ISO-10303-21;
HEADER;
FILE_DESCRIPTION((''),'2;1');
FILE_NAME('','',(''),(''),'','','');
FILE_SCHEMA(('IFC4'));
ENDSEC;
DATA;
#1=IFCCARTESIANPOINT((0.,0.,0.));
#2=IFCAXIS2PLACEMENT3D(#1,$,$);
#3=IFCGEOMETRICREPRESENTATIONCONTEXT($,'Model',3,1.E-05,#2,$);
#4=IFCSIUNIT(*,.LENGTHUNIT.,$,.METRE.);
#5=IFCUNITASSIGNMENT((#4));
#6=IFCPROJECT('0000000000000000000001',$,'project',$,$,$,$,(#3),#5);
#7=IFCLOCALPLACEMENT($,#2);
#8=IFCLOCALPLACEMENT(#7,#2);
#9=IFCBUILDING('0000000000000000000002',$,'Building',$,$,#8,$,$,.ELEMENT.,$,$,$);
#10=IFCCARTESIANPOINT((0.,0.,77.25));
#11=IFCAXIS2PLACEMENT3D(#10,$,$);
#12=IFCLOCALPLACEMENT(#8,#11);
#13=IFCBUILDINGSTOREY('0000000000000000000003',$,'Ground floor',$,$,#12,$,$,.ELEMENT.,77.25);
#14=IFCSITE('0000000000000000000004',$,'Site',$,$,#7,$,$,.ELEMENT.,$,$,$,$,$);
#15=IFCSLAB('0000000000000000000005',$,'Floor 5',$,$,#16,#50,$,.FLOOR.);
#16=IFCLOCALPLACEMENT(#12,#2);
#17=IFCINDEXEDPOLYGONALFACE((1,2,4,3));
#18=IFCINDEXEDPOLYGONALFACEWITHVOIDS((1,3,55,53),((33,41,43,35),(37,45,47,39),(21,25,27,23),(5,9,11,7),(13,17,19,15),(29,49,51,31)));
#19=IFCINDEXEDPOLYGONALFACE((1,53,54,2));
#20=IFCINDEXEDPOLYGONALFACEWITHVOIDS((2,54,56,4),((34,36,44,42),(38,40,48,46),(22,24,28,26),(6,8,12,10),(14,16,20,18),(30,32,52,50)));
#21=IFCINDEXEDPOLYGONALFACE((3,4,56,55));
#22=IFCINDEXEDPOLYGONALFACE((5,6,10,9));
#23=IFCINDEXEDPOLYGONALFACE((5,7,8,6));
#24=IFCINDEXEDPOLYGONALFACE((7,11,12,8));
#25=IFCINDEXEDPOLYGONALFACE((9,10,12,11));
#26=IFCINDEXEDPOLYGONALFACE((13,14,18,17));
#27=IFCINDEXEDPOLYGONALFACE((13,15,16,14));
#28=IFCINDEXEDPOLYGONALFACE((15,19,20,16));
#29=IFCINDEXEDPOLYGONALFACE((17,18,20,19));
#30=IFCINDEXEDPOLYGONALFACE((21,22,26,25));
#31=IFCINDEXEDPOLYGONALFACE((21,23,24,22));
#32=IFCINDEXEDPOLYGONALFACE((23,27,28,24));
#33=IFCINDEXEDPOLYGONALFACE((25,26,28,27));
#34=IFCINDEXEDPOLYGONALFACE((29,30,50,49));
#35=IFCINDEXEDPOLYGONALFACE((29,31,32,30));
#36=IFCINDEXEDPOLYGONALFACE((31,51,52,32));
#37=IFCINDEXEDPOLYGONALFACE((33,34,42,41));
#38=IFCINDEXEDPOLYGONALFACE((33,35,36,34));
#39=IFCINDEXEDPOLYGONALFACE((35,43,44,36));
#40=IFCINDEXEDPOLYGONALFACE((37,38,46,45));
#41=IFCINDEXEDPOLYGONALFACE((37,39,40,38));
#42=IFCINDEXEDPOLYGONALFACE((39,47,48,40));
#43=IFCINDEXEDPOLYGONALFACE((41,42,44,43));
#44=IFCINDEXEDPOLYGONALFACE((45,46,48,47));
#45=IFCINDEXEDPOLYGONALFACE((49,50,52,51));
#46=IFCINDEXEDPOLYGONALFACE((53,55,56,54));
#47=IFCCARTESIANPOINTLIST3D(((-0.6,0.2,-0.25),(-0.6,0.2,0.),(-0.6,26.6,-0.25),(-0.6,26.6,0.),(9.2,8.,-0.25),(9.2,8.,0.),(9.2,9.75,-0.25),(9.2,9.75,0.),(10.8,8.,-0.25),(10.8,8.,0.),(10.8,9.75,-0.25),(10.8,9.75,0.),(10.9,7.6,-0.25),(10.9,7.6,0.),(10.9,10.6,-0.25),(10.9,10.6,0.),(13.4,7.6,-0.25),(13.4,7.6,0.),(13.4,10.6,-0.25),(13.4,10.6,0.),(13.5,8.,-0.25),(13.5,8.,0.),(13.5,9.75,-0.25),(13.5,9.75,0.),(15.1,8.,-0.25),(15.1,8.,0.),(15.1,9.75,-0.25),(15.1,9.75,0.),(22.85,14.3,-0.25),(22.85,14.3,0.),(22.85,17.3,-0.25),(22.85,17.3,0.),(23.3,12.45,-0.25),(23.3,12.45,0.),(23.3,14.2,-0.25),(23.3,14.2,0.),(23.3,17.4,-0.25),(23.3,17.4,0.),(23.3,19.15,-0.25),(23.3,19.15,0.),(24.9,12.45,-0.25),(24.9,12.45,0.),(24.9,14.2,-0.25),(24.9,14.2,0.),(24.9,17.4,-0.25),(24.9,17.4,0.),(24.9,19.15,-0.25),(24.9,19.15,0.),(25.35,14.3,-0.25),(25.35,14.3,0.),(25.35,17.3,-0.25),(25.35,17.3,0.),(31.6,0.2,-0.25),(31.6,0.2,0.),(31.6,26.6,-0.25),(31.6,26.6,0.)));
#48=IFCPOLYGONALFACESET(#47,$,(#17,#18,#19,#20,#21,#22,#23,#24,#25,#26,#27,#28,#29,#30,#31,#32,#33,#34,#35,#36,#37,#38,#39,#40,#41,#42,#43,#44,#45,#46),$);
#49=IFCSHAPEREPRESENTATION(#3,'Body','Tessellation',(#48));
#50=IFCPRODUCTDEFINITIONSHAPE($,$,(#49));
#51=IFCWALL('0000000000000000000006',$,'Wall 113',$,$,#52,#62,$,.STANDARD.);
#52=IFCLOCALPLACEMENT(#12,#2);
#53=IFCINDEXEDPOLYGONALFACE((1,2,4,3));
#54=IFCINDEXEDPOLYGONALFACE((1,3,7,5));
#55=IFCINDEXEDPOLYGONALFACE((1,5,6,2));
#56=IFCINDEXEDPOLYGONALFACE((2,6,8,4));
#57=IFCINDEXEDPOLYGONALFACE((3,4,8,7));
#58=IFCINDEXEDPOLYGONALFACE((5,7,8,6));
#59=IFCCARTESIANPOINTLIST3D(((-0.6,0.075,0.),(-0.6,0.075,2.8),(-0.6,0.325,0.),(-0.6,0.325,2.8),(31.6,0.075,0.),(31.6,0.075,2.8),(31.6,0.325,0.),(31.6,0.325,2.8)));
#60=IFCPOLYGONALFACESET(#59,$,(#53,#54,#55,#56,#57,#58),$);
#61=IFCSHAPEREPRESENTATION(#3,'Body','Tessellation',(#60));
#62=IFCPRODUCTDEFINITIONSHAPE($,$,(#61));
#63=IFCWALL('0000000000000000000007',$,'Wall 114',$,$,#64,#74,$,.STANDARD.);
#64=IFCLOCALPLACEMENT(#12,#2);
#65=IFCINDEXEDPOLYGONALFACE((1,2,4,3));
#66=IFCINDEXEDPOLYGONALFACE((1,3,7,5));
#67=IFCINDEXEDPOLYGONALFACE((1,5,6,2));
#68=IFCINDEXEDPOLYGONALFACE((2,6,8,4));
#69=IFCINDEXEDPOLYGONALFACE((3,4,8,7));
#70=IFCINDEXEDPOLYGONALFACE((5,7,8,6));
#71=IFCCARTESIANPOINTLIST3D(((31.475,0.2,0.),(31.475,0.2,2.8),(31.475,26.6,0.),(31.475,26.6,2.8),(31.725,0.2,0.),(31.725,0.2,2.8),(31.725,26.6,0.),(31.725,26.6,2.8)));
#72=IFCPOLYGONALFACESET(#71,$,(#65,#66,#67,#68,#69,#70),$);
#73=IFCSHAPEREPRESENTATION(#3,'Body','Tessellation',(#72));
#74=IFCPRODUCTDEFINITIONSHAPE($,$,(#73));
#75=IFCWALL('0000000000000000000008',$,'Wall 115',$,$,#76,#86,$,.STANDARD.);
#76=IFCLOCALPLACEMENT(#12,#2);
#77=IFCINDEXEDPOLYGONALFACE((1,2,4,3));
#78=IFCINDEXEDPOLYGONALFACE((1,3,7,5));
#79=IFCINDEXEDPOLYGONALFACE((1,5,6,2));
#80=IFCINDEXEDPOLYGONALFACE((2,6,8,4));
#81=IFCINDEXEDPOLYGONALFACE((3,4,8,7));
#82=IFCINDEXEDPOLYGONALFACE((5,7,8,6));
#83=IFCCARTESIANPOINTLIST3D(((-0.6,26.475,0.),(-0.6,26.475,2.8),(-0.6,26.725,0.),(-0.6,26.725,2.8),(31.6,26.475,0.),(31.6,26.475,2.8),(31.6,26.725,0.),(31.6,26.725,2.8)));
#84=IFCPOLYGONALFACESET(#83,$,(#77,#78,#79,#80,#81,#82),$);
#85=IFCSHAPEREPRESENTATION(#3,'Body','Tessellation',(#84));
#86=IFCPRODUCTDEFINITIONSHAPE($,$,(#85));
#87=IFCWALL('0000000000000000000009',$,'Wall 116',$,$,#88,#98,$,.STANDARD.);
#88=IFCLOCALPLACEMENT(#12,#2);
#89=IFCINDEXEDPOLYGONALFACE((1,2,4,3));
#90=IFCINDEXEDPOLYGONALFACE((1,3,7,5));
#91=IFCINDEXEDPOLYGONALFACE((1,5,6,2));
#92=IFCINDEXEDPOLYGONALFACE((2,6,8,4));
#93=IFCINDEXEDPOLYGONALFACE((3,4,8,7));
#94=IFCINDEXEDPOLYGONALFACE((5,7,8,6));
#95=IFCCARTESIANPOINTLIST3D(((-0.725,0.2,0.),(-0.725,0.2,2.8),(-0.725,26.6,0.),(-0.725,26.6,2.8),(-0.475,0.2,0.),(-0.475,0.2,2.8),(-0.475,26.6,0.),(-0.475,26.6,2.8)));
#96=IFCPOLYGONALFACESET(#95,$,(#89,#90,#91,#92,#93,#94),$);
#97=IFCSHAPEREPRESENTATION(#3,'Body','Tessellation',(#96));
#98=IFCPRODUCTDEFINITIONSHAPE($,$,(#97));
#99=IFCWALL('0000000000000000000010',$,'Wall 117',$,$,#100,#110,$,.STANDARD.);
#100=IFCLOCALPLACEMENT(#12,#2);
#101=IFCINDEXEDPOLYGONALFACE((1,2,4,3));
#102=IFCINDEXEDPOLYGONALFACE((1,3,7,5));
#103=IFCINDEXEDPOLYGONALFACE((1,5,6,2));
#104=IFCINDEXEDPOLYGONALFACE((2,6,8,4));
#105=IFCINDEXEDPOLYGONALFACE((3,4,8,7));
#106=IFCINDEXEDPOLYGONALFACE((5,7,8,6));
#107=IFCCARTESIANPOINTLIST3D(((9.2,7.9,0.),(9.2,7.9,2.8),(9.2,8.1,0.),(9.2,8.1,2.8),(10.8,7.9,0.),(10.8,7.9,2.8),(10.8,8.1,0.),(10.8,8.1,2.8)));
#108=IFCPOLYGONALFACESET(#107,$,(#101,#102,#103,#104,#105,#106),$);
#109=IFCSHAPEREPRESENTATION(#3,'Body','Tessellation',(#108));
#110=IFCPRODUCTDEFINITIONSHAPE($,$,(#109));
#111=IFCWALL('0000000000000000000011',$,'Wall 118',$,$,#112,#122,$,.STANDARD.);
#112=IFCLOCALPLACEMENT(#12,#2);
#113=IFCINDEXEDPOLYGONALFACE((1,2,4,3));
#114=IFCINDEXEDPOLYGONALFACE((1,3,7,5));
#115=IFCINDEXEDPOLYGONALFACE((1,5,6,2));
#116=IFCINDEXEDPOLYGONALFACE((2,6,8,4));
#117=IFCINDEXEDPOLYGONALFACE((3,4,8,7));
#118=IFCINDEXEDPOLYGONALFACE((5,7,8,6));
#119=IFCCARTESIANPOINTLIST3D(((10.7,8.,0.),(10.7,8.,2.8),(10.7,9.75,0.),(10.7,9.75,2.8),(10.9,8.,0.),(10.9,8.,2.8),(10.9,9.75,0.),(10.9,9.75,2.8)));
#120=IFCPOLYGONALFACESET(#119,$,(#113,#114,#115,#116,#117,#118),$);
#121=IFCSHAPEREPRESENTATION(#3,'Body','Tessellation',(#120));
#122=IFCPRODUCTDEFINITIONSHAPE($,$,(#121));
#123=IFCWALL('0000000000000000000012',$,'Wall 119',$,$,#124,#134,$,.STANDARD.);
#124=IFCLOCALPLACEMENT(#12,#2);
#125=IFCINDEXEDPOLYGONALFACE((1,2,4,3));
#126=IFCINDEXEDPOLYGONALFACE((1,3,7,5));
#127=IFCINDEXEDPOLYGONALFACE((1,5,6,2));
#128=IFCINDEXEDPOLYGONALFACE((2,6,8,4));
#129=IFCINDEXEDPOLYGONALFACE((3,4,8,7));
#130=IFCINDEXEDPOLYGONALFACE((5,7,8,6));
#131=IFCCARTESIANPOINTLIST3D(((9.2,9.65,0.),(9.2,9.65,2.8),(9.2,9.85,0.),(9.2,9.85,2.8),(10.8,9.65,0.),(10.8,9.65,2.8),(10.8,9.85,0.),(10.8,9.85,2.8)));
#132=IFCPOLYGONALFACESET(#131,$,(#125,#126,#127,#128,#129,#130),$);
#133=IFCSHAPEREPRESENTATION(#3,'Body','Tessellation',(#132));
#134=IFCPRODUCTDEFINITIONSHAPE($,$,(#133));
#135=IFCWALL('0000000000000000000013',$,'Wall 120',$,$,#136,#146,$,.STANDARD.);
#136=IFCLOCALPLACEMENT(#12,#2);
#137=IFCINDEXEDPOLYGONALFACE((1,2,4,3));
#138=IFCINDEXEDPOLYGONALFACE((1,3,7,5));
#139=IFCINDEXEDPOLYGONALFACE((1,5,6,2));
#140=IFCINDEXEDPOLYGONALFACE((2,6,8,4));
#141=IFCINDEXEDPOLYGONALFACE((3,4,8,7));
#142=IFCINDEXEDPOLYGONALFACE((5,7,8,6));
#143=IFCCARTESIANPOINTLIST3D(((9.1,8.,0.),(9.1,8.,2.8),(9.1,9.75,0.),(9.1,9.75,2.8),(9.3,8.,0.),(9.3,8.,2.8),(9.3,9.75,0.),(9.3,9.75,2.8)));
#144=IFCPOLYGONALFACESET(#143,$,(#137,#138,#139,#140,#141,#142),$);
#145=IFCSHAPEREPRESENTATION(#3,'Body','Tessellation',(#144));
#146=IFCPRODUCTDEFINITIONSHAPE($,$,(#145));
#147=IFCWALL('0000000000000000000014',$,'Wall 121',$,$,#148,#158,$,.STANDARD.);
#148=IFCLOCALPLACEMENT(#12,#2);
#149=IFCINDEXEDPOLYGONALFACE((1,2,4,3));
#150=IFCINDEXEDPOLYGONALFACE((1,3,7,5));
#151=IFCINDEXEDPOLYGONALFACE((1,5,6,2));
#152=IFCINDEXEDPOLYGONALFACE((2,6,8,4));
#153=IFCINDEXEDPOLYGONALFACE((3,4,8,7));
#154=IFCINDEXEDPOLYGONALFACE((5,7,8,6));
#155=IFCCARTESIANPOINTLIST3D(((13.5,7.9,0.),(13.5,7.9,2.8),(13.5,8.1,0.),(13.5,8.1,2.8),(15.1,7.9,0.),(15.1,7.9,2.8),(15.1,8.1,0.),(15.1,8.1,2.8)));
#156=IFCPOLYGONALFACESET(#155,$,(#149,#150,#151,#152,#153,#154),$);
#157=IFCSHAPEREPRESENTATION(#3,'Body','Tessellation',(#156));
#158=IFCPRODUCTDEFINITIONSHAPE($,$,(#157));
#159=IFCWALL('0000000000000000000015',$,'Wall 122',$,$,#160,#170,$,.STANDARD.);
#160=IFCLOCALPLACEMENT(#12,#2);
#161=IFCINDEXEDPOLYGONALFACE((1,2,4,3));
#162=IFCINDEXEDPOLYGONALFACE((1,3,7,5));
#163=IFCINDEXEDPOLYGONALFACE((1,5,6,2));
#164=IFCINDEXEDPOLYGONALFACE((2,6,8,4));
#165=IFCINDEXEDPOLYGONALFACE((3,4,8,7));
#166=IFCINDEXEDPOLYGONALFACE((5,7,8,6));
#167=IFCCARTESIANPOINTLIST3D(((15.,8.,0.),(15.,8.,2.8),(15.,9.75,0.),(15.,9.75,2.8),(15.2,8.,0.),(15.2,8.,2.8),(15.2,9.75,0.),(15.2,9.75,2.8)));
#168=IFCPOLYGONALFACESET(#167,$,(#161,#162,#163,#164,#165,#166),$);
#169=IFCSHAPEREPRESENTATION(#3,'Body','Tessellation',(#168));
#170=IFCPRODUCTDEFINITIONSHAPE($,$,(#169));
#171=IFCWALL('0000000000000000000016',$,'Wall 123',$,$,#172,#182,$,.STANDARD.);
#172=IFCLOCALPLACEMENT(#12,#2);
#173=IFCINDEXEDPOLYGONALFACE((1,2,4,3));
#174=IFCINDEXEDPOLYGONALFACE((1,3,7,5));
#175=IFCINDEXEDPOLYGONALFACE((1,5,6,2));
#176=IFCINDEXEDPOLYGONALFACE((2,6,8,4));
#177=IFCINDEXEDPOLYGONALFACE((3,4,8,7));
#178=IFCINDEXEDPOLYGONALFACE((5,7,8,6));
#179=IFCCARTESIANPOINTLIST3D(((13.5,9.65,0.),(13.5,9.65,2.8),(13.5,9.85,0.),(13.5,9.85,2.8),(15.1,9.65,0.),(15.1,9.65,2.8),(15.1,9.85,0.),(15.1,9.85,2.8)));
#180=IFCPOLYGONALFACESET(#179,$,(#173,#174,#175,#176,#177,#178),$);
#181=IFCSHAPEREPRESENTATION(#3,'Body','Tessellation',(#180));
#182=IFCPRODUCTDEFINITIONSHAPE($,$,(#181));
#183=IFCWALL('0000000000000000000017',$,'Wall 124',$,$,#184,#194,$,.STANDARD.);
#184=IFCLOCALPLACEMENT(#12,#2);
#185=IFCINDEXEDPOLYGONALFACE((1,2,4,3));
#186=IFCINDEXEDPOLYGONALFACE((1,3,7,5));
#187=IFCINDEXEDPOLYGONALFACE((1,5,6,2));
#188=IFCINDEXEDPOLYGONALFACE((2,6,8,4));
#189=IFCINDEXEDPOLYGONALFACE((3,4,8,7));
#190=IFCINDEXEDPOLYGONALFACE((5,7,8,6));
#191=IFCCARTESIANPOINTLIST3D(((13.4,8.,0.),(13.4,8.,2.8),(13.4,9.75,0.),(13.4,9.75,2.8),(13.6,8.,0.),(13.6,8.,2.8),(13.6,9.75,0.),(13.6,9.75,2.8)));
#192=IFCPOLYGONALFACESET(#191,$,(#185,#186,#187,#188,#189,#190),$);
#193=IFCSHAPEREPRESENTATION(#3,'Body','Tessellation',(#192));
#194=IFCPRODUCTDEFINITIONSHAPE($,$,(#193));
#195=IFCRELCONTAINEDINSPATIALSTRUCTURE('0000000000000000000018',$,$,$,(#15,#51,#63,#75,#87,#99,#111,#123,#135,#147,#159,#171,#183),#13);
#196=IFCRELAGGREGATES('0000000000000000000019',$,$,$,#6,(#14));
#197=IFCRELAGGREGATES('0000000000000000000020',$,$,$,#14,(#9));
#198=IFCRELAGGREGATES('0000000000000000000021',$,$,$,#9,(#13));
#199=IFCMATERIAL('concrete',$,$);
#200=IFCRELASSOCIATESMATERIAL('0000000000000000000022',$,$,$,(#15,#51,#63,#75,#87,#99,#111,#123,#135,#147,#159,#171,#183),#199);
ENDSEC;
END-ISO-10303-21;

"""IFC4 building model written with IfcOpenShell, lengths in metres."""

from ifc_helpers import new_model, si_unit, frame, frame_2d, origin, place, context, project, spatial, polyline, rectangle, outline, extrude, material, element, save


model = new_model("IFC4")

# Units and contexts
model_context = context("Model", 3, precision=1e-05, world=origin())
ifc_project = project(units=[si_unit("LENGTHUNIT", "METRE")], contexts=[model_context])

# Site, building, storey
site_placement = place(None, origin())
site = spatial("IfcSite", under=ifc_project, at=site_placement, Name="Site", CompositionType="ELEMENT")
building_placement = place(site_placement, origin())
building = spatial("IfcBuilding", under=site, at=building_placement, Name="Building", CompositionType="ELEMENT")
storey_placement = place(building_placement, frame((0.0, 0.0, 77.25)))
storey = spatial("IfcBuildingStorey", under=building, at=storey_placement, Name="Ground floor", CompositionType="ELEMENT", Elevation=77.25)

# Slab
ifc_material = material(Name="concrete")
slab_placement = place(storey_placement, frame((0.0, 0.0, -0.25), z_axis=(0.0, 0.0, 1.0), x_axis=(1.0, 0.0, 0.0)))
element("IfcSlab", 1, at=slab_placement, inside=storey, material=ifc_material, Name="Floor 5", PredefinedType="FLOOR", context=model_context, shape_type="SweptSolid", body=[
    extrude(outline(polyline([(-0.6, 0.2), (31.6, 0.2), (31.6, 26.6), (-0.6, 26.6), (-0.6, 0.2)]), holes=[polyline([(10.9, 7.6), (13.4, 7.6), (13.4, 10.6), (10.9, 10.6), (10.9, 7.6)]), polyline([(9.2, 8.0), (10.8, 8.0), (10.8, 9.75), (9.2, 9.75), (9.2, 8.0)]), polyline([(13.5, 8.0), (15.1, 8.0), (15.1, 9.75), (13.5, 9.75), (13.5, 8.0)]), polyline([(22.85, 14.3), (25.35, 14.3), (25.35, 17.3), (22.85, 17.3), (22.85, 14.3)]), polyline([(23.3, 17.4), (24.9, 17.4), (24.9, 19.15), (23.3, 19.15), (23.3, 17.4)]), polyline([(23.3, 12.45), (24.9, 12.45), (24.9, 14.2), (23.3, 14.2), (23.3, 12.45)])]), origin(), (0.0, 0.0, 1.0), 0.25),
])

# Walls
wall_1_placement = place(storey_placement, frame((-0.6, 0.2, 0.0), z_axis=(0.0, 0.0, 1.0), x_axis=(1.0, 0.0, 0.0)))
element("IfcWall", 2, at=wall_1_placement, inside=storey, material=ifc_material, Name="Wall 113", PredefinedType="STANDARD", context=model_context, shape_type="SweptSolid", body=[
    extrude(rectangle(XDim=32.2, YDim=0.25, at=frame_2d((16.1, 0.0))), origin(), (0.0, 0.0, 1.0), 2.8),
])
wall_2_placement = place(storey_placement, frame((31.6, 0.2, 0.0), z_axis=(0.0, 0.0, 1.0), x_axis=(0.0, 1.0, 0.0)))
element("IfcWall", 3, at=wall_2_placement, inside=storey, material=ifc_material, Name="Wall 114", PredefinedType="STANDARD", context=model_context, shape_type="SweptSolid", body=[
    extrude(rectangle(XDim=26.4, YDim=0.25, at=frame_2d((13.2, 0.0))), origin(), (0.0, 0.0, 1.0), 2.8),
])
wall_3_placement = place(storey_placement, frame((31.6, 26.6, 0.0), z_axis=(0.0, 0.0, 1.0), x_axis=(-1.0, 0.0, 0.0)))
element("IfcWall", 4, at=wall_3_placement, inside=storey, material=ifc_material, Name="Wall 115", PredefinedType="STANDARD", context=model_context, shape_type="SweptSolid", body=[
    extrude(rectangle(XDim=32.2, YDim=0.25, at=frame_2d((16.1, 0.0))), origin(), (0.0, 0.0, 1.0), 2.8),
])
wall_4_placement = place(storey_placement, frame((-0.6, 26.6, 0.0), z_axis=(0.0, 0.0, 1.0), x_axis=(0.0, -1.0, 0.0)))
element("IfcWall", 5, at=wall_4_placement, inside=storey, material=ifc_material, Name="Wall 116", PredefinedType="STANDARD", context=model_context, shape_type="SweptSolid", body=[
    extrude(rectangle(XDim=26.4, YDim=0.25, at=frame_2d((13.2, 0.0))), origin(), (0.0, 0.0, 1.0), 2.8),
])
wall_5_placement = place(storey_placement, frame((9.2, 8.0, 0.0), z_axis=(0.0, 0.0, 1.0), x_axis=(1.0, 0.0, 0.0)))
element("IfcWall", 6, at=wall_5_placement, inside=storey, material=ifc_material, Name="Wall 117", PredefinedType="STANDARD", context=model_context, shape_type="SweptSolid", body=[
    extrude(rectangle(XDim=1.6, YDim=0.2, at=frame_2d((0.8, 0.0))), origin(), (0.0, 0.0, 1.0), 2.8),
])
wall_6_placement = place(storey_placement, frame((10.8, 8.0, 0.0), z_axis=(0.0, 0.0, 1.0), x_axis=(0.0, 1.0, 0.0)))
element("IfcWall", 7, at=wall_6_placement, inside=storey, material=ifc_material, Name="Wall 118", PredefinedType="STANDARD", context=model_context, shape_type="SweptSolid", body=[
    extrude(rectangle(XDim=1.75, YDim=0.2, at=frame_2d((0.875, 0.0))), origin(), (0.0, 0.0, 1.0), 2.8),
])
wall_7_placement = place(storey_placement, frame((10.8, 9.75, 0.0), z_axis=(0.0, 0.0, 1.0), x_axis=(-1.0, 0.0, 0.0)))
element("IfcWall", 8, at=wall_7_placement, inside=storey, material=ifc_material, Name="Wall 119", PredefinedType="STANDARD", context=model_context, shape_type="SweptSolid", body=[
    extrude(rectangle(XDim=1.6, YDim=0.2, at=frame_2d((0.8, 0.0))), origin(), (0.0, 0.0, 1.0), 2.8),
])
wall_8_placement = place(storey_placement, frame((9.2, 9.75, 0.0), z_axis=(0.0, 0.0, 1.0), x_axis=(0.0, -1.0, 0.0)))
element("IfcWall", 9, at=wall_8_placement, inside=storey, material=ifc_material, Name="Wall 120", PredefinedType="STANDARD", context=model_context, shape_type="SweptSolid", body=[
    extrude(rectangle(XDim=1.75, YDim=0.2, at=frame_2d((0.875, 0.0))), origin(), (0.0, 0.0, 1.0), 2.8),
])
wall_9_placement = place(storey_placement, frame((13.5, 8.0, 0.0), z_axis=(0.0, 0.0, 1.0), x_axis=(1.0, 0.0, 0.0)))
element("IfcWall", 10, at=wall_9_placement, inside=storey, material=ifc_material, Name="Wall 121", PredefinedType="STANDARD", context=model_context, shape_type="SweptSolid", body=[
    extrude(rectangle(XDim=1.6, YDim=0.2, at=frame_2d((0.8, 0.0))), origin(), (0.0, 0.0, 1.0), 2.8),
])
wall_10_placement = place(storey_placement, frame((15.1, 8.0, 0.0), z_axis=(0.0, 0.0, 1.0), x_axis=(0.0, 1.0, 0.0)))
element("IfcWall", 11, at=wall_10_placement, inside=storey, material=ifc_material, Name="Wall 122", PredefinedType="STANDARD", context=model_context, shape_type="SweptSolid", body=[
    extrude(rectangle(XDim=1.75, YDim=0.2, at=frame_2d((0.875, 0.0))), origin(), (0.0, 0.0, 1.0), 2.8),
])
wall_11_placement = place(storey_placement, frame((15.1, 9.75, 0.0), z_axis=(0.0, 0.0, 1.0), x_axis=(-1.0, 0.0, 0.0)))
element("IfcWall", 12, at=wall_11_placement, inside=storey, material=ifc_material, Name="Wall 123", PredefinedType="STANDARD", context=model_context, shape_type="SweptSolid", body=[
    extrude(rectangle(XDim=1.6, YDim=0.2, at=frame_2d((0.8, 0.0))), origin(), (0.0, 0.0, 1.0), 2.8),
])
wall_12_placement = place(storey_placement, frame((13.5, 9.75, 0.0), z_axis=(0.0, 0.0, 1.0), x_axis=(0.0, -1.0, 0.0)))
element("IfcWall", 13, at=wall_12_placement, inside=storey, material=ifc_material, Name="Wall 124", PredefinedType="STANDARD", context=model_context, shape_type="SweptSolid", body=[
    extrude(rectangle(XDim=1.75, YDim=0.2, at=frame_2d((0.875, 0.0))), origin(), (0.0, 0.0, 1.0), 2.8),
])

save(model, "model.ifc")
